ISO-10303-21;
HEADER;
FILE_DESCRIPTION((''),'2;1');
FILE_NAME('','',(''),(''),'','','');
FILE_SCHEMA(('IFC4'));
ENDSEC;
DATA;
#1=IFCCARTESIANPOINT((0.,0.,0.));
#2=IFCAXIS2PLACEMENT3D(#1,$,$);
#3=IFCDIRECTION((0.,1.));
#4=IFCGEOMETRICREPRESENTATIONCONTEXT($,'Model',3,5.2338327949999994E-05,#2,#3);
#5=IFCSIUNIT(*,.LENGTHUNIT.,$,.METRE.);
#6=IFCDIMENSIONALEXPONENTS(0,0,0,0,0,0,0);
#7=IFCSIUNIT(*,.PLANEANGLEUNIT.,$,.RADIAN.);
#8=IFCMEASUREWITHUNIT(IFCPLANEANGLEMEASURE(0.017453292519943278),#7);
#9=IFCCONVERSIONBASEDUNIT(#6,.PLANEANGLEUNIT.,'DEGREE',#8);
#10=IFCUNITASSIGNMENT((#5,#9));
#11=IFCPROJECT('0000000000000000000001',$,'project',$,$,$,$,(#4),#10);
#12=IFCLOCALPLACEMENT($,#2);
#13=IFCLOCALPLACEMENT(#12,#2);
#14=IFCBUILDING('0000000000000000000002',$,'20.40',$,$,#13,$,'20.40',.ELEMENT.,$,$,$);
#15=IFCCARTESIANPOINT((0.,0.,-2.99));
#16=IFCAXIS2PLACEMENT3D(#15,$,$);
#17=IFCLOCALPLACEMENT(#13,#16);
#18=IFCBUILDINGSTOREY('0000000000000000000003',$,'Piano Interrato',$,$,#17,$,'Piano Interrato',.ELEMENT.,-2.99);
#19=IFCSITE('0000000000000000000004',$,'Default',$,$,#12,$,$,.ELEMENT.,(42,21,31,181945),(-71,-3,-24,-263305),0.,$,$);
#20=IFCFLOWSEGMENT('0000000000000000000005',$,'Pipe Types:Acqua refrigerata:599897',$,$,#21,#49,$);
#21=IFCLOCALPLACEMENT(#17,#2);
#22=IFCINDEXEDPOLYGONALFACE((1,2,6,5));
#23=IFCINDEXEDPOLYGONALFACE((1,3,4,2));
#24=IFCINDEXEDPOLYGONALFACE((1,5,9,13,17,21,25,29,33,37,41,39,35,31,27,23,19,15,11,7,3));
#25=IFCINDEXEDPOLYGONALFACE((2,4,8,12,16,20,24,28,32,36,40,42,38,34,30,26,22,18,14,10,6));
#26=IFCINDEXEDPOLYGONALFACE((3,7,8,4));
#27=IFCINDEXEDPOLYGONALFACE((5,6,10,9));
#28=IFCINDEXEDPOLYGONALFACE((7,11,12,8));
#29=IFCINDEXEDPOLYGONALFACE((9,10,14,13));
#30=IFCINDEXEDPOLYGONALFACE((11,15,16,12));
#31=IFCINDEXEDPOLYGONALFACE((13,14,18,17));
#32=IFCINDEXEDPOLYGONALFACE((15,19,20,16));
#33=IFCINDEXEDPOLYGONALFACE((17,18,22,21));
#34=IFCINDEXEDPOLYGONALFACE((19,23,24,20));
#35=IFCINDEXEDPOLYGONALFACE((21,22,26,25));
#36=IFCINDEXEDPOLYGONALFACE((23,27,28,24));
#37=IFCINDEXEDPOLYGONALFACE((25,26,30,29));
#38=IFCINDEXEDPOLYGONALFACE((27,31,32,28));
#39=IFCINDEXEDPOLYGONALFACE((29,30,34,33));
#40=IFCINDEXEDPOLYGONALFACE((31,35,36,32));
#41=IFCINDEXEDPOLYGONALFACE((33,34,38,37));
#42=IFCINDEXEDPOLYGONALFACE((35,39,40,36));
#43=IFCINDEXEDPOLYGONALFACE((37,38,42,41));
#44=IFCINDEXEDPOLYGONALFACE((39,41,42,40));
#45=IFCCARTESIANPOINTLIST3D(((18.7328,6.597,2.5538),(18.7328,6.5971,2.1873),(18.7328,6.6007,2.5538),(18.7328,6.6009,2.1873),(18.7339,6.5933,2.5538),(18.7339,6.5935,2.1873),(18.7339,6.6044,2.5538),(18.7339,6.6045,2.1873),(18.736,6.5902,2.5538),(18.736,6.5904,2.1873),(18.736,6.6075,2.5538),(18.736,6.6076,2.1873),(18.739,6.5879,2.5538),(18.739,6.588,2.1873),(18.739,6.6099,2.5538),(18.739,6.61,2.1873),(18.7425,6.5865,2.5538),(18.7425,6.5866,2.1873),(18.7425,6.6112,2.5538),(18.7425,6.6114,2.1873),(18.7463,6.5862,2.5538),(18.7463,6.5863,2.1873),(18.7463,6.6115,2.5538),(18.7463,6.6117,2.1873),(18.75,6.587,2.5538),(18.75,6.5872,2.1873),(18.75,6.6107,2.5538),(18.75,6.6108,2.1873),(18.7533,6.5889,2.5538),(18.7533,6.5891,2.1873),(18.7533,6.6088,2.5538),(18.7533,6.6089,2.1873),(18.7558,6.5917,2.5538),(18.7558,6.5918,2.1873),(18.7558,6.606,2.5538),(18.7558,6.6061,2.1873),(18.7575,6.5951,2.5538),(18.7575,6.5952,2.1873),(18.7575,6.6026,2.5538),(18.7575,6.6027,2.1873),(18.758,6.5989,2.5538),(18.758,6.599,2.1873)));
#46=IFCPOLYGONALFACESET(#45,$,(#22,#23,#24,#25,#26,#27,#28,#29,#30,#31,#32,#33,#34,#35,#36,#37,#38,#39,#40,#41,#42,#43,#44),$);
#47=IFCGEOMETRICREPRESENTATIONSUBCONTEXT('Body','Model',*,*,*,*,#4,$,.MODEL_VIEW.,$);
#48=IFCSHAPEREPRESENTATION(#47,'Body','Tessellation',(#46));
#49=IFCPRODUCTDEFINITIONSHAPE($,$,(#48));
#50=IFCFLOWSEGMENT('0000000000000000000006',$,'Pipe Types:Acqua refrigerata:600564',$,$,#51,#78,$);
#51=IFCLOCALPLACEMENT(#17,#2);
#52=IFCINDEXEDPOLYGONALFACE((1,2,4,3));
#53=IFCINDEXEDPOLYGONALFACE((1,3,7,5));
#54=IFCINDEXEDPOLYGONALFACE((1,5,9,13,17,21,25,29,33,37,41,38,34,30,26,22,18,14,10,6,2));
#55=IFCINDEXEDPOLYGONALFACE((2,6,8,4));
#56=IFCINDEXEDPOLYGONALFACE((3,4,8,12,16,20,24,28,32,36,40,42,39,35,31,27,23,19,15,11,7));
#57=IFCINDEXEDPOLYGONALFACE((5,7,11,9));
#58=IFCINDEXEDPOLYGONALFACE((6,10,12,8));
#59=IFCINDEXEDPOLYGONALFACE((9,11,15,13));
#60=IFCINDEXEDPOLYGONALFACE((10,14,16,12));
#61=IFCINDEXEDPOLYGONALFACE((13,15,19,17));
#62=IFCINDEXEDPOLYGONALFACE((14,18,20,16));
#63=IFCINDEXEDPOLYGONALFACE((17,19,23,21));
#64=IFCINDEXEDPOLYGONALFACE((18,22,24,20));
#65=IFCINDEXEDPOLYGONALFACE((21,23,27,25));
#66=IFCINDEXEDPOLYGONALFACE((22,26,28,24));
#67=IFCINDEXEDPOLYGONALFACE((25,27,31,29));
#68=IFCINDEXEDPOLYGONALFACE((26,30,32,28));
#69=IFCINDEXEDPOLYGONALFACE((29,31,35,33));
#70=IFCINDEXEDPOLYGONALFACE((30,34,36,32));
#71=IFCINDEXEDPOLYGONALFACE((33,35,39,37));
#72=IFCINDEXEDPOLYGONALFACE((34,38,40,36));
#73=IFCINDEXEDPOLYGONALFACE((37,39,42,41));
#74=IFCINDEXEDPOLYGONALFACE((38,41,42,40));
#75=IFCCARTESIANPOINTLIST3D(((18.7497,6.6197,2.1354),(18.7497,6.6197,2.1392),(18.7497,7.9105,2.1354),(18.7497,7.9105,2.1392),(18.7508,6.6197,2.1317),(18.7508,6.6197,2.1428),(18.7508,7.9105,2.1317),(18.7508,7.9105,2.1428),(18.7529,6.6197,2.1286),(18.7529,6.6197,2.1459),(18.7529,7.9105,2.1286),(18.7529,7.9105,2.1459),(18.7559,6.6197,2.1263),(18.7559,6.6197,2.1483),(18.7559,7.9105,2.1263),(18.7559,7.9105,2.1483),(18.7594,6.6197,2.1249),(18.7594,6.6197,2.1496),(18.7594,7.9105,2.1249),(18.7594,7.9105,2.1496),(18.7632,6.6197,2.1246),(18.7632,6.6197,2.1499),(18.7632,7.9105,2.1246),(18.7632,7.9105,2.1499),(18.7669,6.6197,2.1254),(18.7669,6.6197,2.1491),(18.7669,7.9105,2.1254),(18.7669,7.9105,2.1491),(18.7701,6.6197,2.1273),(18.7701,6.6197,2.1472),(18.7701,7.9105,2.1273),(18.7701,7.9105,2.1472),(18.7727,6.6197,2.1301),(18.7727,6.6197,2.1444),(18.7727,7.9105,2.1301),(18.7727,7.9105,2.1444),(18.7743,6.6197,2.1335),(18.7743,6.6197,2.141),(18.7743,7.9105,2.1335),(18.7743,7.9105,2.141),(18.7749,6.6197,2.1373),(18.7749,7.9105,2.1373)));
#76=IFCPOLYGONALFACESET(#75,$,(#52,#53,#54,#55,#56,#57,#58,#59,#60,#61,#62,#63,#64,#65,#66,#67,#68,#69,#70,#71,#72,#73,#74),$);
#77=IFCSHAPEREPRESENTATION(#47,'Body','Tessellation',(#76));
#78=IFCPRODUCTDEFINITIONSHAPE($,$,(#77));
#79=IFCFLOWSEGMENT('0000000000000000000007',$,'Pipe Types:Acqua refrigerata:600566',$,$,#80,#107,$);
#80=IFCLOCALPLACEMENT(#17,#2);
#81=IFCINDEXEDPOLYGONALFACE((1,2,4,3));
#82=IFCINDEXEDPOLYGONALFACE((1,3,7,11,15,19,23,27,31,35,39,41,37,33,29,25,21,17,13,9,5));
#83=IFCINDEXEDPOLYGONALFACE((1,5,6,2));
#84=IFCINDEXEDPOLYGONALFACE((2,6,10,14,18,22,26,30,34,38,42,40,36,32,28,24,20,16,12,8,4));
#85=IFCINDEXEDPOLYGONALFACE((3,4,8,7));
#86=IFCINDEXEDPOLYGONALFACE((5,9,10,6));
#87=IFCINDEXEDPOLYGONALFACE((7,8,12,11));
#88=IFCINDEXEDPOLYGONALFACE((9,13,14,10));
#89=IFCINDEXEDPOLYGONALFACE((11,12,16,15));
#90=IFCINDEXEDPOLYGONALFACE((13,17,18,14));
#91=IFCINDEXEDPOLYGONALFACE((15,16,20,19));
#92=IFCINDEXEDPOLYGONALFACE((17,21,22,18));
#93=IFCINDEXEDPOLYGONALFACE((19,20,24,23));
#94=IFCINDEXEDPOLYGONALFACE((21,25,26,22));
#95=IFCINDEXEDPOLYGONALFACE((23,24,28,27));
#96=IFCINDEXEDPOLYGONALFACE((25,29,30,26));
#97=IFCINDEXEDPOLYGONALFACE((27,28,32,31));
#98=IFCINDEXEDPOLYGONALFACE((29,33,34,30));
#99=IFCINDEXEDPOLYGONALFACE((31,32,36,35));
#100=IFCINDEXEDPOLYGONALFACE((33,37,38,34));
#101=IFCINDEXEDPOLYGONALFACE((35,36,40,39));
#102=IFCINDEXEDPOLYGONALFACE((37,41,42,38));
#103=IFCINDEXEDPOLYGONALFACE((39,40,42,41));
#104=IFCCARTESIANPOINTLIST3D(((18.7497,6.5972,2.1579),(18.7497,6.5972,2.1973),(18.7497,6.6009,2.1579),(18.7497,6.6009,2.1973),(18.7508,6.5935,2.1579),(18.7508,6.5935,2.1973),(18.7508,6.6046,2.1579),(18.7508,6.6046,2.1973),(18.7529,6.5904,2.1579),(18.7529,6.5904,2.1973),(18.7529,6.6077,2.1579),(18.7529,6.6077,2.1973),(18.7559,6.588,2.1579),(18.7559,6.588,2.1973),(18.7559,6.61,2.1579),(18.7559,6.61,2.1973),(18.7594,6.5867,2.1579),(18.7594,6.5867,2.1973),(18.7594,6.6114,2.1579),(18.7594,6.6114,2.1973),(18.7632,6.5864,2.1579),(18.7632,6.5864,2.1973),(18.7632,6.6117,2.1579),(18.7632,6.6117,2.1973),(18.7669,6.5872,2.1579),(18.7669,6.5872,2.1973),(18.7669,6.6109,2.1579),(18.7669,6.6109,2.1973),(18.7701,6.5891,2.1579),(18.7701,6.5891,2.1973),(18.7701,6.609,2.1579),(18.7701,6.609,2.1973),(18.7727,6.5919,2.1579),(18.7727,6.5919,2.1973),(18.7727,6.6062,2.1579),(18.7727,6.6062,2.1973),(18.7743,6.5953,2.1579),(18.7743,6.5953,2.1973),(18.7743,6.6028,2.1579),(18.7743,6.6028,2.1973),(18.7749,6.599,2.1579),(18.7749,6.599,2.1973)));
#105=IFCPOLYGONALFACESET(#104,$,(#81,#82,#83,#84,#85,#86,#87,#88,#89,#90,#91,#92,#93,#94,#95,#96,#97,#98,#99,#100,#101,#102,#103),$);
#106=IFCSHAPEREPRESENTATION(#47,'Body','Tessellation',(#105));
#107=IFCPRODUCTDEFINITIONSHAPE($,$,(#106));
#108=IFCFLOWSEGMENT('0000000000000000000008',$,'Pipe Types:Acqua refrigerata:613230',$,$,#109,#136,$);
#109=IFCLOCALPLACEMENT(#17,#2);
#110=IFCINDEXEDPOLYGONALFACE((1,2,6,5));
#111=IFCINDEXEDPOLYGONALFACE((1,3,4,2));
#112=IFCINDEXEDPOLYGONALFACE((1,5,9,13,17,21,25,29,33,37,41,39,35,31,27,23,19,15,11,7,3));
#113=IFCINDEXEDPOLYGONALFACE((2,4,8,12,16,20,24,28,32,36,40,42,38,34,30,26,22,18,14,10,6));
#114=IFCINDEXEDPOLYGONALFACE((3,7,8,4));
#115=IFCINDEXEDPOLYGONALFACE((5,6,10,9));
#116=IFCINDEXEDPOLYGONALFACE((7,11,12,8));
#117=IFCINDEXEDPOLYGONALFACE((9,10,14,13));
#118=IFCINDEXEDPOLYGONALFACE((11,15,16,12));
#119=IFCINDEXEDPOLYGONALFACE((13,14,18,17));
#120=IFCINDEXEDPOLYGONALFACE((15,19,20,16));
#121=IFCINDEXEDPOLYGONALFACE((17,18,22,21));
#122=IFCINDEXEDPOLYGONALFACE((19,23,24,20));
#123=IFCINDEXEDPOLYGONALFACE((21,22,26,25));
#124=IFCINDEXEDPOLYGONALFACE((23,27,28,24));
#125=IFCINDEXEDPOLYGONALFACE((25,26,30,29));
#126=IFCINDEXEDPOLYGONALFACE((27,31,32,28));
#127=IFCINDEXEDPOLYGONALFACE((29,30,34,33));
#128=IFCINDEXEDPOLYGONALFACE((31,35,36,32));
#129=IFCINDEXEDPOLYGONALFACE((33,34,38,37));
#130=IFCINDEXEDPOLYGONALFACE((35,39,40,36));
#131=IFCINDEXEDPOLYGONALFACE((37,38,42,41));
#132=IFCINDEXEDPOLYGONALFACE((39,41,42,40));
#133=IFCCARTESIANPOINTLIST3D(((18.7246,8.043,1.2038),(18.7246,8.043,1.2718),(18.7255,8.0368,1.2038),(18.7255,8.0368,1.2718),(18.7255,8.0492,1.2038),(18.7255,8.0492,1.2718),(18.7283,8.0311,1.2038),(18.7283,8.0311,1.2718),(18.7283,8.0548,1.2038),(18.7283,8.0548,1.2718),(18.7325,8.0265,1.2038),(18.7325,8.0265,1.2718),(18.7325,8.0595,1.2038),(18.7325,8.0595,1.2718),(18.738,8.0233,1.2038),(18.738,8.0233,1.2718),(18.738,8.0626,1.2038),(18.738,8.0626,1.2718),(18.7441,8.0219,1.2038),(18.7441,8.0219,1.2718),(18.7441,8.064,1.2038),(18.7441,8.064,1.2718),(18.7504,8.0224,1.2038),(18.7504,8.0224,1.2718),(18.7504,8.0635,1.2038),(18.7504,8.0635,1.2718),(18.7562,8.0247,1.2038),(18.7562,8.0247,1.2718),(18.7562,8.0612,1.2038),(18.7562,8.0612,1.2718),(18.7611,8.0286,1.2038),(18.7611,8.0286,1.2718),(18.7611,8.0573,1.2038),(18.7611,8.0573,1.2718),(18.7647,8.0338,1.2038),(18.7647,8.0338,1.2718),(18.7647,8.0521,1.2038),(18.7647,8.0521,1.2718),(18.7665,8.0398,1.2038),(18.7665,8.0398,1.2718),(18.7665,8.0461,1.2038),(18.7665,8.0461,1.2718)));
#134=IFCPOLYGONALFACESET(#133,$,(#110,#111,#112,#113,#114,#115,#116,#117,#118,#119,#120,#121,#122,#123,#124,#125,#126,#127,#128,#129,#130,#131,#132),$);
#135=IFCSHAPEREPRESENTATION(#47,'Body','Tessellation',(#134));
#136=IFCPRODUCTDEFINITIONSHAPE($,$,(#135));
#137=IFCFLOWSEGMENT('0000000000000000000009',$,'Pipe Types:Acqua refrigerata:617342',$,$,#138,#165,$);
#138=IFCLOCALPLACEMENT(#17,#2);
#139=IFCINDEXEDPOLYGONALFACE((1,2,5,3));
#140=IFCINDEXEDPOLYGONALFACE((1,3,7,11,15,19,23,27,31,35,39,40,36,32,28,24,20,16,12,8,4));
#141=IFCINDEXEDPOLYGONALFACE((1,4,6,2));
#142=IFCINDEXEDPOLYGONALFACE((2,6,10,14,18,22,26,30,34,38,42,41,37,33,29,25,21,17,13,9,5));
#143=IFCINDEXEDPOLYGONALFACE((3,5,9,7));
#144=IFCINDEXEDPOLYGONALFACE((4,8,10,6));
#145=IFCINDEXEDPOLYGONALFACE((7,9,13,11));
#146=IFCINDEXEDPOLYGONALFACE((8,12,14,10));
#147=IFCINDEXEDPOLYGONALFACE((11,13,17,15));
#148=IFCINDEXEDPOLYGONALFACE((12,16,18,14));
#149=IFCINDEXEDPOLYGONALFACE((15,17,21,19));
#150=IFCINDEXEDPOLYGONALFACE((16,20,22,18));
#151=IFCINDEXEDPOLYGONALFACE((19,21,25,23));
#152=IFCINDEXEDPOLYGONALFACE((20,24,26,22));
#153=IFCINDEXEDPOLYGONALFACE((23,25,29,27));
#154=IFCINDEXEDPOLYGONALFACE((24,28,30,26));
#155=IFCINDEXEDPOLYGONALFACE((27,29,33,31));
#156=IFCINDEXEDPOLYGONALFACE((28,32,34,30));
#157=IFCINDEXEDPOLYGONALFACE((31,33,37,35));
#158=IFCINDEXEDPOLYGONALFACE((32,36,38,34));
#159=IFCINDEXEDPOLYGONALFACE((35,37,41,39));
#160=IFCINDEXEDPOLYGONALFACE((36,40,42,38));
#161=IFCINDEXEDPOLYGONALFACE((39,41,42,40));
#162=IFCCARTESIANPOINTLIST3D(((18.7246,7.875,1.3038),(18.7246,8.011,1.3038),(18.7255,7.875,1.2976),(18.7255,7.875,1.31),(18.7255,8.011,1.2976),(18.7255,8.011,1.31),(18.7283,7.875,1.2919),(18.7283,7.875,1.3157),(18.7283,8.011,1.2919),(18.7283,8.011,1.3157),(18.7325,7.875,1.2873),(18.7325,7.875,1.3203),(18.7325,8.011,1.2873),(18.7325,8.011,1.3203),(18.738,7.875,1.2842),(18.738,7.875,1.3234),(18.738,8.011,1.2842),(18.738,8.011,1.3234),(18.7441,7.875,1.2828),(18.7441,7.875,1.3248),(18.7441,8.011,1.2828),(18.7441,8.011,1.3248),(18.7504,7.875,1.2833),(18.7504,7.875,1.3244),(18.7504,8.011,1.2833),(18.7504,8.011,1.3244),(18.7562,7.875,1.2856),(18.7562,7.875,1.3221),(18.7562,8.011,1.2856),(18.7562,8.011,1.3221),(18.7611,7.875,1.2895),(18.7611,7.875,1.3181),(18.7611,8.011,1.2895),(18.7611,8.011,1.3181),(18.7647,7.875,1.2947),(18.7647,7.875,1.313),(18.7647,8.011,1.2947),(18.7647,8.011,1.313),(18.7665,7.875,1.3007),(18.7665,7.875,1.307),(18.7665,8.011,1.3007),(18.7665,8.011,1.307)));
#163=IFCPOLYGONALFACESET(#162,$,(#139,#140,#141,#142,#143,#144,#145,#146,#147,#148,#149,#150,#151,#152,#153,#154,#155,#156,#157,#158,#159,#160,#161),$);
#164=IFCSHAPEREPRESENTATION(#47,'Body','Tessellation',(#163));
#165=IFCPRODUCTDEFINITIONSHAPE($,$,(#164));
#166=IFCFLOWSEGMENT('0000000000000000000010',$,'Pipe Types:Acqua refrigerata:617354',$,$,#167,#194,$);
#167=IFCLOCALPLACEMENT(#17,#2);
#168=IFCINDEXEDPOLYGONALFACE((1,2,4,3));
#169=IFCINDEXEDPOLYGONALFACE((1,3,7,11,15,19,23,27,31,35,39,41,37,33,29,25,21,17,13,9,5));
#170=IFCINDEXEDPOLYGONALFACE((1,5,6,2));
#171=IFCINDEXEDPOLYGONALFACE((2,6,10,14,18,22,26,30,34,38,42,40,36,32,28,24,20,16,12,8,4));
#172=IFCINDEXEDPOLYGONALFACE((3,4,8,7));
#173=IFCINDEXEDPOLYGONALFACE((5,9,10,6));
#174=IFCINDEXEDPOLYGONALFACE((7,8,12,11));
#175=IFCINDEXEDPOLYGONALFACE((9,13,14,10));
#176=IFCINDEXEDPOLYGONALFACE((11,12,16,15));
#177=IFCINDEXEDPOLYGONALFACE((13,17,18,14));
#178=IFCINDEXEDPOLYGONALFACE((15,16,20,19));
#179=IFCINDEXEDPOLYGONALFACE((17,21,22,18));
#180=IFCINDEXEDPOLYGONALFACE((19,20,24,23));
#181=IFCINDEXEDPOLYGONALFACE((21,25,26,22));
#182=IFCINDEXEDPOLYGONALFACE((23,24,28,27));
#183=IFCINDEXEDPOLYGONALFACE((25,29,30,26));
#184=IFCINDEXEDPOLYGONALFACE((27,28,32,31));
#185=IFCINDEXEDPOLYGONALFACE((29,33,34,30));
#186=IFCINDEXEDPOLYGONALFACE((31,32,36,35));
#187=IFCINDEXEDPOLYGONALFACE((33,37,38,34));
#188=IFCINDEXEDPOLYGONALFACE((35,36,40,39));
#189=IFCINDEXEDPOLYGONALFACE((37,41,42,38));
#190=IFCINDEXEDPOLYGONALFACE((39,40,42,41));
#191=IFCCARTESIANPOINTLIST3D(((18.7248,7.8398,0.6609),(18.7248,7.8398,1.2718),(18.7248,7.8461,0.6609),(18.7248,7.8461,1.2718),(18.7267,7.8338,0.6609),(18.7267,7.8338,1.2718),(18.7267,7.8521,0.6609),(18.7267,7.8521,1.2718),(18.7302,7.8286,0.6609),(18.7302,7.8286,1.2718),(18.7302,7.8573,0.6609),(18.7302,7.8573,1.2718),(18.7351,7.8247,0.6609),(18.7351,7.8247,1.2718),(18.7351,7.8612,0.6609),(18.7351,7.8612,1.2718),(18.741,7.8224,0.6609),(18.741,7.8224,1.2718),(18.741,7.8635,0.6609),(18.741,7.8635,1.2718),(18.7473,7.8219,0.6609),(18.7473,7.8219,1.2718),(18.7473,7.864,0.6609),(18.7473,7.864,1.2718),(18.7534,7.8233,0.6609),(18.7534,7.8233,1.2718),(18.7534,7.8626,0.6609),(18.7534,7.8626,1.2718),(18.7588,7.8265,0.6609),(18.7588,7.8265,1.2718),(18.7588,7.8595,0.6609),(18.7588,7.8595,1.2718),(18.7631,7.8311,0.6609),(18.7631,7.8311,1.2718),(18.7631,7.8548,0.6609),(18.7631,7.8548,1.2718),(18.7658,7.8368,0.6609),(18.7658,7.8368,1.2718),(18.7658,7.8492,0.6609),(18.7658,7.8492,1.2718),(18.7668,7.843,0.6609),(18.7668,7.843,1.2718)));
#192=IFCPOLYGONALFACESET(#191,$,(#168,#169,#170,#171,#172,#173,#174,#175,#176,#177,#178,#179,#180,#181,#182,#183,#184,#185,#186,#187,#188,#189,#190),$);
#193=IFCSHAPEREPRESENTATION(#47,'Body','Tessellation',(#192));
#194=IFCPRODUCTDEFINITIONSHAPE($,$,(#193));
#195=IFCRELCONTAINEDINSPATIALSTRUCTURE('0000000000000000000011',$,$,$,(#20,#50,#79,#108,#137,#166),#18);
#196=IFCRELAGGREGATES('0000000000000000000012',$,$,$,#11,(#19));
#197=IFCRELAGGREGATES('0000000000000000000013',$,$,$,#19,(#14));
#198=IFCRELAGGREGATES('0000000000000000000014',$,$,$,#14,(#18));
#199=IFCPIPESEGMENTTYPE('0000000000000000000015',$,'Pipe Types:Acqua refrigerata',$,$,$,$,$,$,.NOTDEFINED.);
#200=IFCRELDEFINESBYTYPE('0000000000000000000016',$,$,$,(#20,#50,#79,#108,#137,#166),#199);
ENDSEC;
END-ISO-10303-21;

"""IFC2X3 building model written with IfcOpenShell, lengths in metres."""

from ifc_helpers import new_model, entity, si_unit, converted_unit, direction, frame, frame_2d, origin, origin_2d_with_axis, place, context, subcontext, project, spatial, circle, extrude, type_object, element, save


model = new_model("IFC2X3")

# Units and contexts
model_context = context("Model", 3, precision=5.2338327949999994e-05, world=origin(), true_north=direction((0.0, 1.0)))
body_context = subcontext(model_context, "Body", "Model", "MODEL_VIEW")
ifc_project = project(units=[si_unit("LENGTHUNIT", "METRE"), converted_unit("PLANEANGLEUNIT", "DEGREE", entity("IfcPlaneAngleMeasure", 0.017453292519943278), si_unit("PLANEANGLEUNIT", "RADIAN"), dimensions=[0, 0, 0, 0, 0, 0, 0])], contexts=[model_context])

# Site, building, storey
site_placement = place(None, origin())
site = spatial("IfcSite", under=ifc_project, at=site_placement, Name="Default", CompositionType="ELEMENT", RefLatitude=(42, 21, 31, 181945), RefLongitude=(-71, -3, -24, -263305), RefElevation=0.0)
building_placement = place(site_placement, origin())
building = spatial("IfcBuilding", under=site, at=building_placement, Name="20.40", LongName="20.40", CompositionType="ELEMENT")
storey_placement = place(building_placement, frame((0.0, 0.0, -2.99)))
storey = spatial("IfcBuildingStorey", under=building, at=storey_placement, Name="Piano Interrato", LongName="Piano Interrato", CompositionType="ELEMENT", Elevation=-2.99)

# Flow segments
pipe_segment_type_1 = type_object("IfcPipeSegmentType", Name="Pipe Types:Acqua refrigerata", PredefinedType="NOTDEFINED")
flow_segment_1_placement = place(storey_placement, origin())
element("IfcFlowSegment", 1, at=flow_segment_1_placement, inside=storey, type_object=pipe_segment_type_1, Name="Pipe Types:Acqua refrigerata:599897", context=body_context, shape_type="SweptSolid", body=[
    extrude(circle(Radius=0.0127, at=frame_2d((0.0, 0.0), x_axis=(1.0, 0.0))), frame((18.7453, 6.599, 2.1873), z_axis=(0.0, -0.000383, 1.0), x_axis=(1.0, 0.0, 0.0)), (0.0, 0.0, 1.0), 0.3665),
])
flow_segment_2_placement = place(storey_placement, origin())
element("IfcFlowSegment", 2, at=flow_segment_2_placement, inside=storey, type_object=pipe_segment_type_1, Name="Pipe Types:Acqua refrigerata:600564", context=body_context, shape_type="SweptSolid", body=[
    extrude(circle(Radius=0.0127, at=origin_2d_with_axis()), frame((18.7622, 6.6197, 2.1373), z_axis=(0.0, 1.0, 0.0), x_axis=(1.0, 0.0, 0.0)), (0.0, 0.0, 1.0), 1.2908),
])
flow_segment_3_placement = place(storey_placement, origin())
element("IfcFlowSegment", 3, at=flow_segment_3_placement, inside=storey, type_object=pipe_segment_type_1, Name="Pipe Types:Acqua refrigerata:600566", context=body_context, shape_type="SweptSolid", body=[
    extrude(circle(Radius=0.0127, at=origin_2d_with_axis()), frame((18.7622, 6.599, 2.1579)), (0.0, 0.0, 1.0), 0.0394),
])
flow_segment_4_placement = place(storey_placement, origin())
element("IfcFlowSegment", 4, at=flow_segment_4_placement, inside=storey, type_object=pipe_segment_type_1, Name="Pipe Types:Acqua refrigerata:613230", context=body_context, shape_type="SweptSolid", body=[
    extrude(circle(Radius=0.0211, at=frame_2d((0.0, 0.0), x_axis=(1.0, 0.0))), frame((18.7457, 8.043, 1.2038), z_axis=(0.0, 0.0, 1.0), x_axis=(-1.0, 0.0, 0.0)), (0.0, 0.0, 1.0), 0.068),
])
flow_segment_5_placement = place(storey_placement, origin())
element("IfcFlowSegment", 5, at=flow_segment_5_placement, inside=storey, type_object=pipe_segment_type_1, Name="Pipe Types:Acqua refrigerata:617342", context=body_context, shape_type="SweptSolid", body=[
    extrude(circle(Radius=0.0211, at=frame_2d((0.0, 0.0), x_axis=(1.0, 0.0))), frame((18.7457, 7.875, 1.3038), z_axis=(0.0, 1.0, 0.0), x_axis=(-1.0, 0.0, 0.0)), (0.0, 0.0, 1.0), 0.136),
])
flow_segment_6_placement = place(storey_placement, origin())
element("IfcFlowSegment", 6, at=flow_segment_6_placement, inside=storey, type_object=pipe_segment_type_1, Name="Pipe Types:Acqua refrigerata:617354", context=body_context, shape_type="SweptSolid", body=[
    extrude(circle(Radius=0.0211, at=origin_2d_with_axis()), frame((18.7457, 7.843, 0.6609)), (0.0, 0.0, 1.0), 0.6109),
])

save(model, "model.ifc")
